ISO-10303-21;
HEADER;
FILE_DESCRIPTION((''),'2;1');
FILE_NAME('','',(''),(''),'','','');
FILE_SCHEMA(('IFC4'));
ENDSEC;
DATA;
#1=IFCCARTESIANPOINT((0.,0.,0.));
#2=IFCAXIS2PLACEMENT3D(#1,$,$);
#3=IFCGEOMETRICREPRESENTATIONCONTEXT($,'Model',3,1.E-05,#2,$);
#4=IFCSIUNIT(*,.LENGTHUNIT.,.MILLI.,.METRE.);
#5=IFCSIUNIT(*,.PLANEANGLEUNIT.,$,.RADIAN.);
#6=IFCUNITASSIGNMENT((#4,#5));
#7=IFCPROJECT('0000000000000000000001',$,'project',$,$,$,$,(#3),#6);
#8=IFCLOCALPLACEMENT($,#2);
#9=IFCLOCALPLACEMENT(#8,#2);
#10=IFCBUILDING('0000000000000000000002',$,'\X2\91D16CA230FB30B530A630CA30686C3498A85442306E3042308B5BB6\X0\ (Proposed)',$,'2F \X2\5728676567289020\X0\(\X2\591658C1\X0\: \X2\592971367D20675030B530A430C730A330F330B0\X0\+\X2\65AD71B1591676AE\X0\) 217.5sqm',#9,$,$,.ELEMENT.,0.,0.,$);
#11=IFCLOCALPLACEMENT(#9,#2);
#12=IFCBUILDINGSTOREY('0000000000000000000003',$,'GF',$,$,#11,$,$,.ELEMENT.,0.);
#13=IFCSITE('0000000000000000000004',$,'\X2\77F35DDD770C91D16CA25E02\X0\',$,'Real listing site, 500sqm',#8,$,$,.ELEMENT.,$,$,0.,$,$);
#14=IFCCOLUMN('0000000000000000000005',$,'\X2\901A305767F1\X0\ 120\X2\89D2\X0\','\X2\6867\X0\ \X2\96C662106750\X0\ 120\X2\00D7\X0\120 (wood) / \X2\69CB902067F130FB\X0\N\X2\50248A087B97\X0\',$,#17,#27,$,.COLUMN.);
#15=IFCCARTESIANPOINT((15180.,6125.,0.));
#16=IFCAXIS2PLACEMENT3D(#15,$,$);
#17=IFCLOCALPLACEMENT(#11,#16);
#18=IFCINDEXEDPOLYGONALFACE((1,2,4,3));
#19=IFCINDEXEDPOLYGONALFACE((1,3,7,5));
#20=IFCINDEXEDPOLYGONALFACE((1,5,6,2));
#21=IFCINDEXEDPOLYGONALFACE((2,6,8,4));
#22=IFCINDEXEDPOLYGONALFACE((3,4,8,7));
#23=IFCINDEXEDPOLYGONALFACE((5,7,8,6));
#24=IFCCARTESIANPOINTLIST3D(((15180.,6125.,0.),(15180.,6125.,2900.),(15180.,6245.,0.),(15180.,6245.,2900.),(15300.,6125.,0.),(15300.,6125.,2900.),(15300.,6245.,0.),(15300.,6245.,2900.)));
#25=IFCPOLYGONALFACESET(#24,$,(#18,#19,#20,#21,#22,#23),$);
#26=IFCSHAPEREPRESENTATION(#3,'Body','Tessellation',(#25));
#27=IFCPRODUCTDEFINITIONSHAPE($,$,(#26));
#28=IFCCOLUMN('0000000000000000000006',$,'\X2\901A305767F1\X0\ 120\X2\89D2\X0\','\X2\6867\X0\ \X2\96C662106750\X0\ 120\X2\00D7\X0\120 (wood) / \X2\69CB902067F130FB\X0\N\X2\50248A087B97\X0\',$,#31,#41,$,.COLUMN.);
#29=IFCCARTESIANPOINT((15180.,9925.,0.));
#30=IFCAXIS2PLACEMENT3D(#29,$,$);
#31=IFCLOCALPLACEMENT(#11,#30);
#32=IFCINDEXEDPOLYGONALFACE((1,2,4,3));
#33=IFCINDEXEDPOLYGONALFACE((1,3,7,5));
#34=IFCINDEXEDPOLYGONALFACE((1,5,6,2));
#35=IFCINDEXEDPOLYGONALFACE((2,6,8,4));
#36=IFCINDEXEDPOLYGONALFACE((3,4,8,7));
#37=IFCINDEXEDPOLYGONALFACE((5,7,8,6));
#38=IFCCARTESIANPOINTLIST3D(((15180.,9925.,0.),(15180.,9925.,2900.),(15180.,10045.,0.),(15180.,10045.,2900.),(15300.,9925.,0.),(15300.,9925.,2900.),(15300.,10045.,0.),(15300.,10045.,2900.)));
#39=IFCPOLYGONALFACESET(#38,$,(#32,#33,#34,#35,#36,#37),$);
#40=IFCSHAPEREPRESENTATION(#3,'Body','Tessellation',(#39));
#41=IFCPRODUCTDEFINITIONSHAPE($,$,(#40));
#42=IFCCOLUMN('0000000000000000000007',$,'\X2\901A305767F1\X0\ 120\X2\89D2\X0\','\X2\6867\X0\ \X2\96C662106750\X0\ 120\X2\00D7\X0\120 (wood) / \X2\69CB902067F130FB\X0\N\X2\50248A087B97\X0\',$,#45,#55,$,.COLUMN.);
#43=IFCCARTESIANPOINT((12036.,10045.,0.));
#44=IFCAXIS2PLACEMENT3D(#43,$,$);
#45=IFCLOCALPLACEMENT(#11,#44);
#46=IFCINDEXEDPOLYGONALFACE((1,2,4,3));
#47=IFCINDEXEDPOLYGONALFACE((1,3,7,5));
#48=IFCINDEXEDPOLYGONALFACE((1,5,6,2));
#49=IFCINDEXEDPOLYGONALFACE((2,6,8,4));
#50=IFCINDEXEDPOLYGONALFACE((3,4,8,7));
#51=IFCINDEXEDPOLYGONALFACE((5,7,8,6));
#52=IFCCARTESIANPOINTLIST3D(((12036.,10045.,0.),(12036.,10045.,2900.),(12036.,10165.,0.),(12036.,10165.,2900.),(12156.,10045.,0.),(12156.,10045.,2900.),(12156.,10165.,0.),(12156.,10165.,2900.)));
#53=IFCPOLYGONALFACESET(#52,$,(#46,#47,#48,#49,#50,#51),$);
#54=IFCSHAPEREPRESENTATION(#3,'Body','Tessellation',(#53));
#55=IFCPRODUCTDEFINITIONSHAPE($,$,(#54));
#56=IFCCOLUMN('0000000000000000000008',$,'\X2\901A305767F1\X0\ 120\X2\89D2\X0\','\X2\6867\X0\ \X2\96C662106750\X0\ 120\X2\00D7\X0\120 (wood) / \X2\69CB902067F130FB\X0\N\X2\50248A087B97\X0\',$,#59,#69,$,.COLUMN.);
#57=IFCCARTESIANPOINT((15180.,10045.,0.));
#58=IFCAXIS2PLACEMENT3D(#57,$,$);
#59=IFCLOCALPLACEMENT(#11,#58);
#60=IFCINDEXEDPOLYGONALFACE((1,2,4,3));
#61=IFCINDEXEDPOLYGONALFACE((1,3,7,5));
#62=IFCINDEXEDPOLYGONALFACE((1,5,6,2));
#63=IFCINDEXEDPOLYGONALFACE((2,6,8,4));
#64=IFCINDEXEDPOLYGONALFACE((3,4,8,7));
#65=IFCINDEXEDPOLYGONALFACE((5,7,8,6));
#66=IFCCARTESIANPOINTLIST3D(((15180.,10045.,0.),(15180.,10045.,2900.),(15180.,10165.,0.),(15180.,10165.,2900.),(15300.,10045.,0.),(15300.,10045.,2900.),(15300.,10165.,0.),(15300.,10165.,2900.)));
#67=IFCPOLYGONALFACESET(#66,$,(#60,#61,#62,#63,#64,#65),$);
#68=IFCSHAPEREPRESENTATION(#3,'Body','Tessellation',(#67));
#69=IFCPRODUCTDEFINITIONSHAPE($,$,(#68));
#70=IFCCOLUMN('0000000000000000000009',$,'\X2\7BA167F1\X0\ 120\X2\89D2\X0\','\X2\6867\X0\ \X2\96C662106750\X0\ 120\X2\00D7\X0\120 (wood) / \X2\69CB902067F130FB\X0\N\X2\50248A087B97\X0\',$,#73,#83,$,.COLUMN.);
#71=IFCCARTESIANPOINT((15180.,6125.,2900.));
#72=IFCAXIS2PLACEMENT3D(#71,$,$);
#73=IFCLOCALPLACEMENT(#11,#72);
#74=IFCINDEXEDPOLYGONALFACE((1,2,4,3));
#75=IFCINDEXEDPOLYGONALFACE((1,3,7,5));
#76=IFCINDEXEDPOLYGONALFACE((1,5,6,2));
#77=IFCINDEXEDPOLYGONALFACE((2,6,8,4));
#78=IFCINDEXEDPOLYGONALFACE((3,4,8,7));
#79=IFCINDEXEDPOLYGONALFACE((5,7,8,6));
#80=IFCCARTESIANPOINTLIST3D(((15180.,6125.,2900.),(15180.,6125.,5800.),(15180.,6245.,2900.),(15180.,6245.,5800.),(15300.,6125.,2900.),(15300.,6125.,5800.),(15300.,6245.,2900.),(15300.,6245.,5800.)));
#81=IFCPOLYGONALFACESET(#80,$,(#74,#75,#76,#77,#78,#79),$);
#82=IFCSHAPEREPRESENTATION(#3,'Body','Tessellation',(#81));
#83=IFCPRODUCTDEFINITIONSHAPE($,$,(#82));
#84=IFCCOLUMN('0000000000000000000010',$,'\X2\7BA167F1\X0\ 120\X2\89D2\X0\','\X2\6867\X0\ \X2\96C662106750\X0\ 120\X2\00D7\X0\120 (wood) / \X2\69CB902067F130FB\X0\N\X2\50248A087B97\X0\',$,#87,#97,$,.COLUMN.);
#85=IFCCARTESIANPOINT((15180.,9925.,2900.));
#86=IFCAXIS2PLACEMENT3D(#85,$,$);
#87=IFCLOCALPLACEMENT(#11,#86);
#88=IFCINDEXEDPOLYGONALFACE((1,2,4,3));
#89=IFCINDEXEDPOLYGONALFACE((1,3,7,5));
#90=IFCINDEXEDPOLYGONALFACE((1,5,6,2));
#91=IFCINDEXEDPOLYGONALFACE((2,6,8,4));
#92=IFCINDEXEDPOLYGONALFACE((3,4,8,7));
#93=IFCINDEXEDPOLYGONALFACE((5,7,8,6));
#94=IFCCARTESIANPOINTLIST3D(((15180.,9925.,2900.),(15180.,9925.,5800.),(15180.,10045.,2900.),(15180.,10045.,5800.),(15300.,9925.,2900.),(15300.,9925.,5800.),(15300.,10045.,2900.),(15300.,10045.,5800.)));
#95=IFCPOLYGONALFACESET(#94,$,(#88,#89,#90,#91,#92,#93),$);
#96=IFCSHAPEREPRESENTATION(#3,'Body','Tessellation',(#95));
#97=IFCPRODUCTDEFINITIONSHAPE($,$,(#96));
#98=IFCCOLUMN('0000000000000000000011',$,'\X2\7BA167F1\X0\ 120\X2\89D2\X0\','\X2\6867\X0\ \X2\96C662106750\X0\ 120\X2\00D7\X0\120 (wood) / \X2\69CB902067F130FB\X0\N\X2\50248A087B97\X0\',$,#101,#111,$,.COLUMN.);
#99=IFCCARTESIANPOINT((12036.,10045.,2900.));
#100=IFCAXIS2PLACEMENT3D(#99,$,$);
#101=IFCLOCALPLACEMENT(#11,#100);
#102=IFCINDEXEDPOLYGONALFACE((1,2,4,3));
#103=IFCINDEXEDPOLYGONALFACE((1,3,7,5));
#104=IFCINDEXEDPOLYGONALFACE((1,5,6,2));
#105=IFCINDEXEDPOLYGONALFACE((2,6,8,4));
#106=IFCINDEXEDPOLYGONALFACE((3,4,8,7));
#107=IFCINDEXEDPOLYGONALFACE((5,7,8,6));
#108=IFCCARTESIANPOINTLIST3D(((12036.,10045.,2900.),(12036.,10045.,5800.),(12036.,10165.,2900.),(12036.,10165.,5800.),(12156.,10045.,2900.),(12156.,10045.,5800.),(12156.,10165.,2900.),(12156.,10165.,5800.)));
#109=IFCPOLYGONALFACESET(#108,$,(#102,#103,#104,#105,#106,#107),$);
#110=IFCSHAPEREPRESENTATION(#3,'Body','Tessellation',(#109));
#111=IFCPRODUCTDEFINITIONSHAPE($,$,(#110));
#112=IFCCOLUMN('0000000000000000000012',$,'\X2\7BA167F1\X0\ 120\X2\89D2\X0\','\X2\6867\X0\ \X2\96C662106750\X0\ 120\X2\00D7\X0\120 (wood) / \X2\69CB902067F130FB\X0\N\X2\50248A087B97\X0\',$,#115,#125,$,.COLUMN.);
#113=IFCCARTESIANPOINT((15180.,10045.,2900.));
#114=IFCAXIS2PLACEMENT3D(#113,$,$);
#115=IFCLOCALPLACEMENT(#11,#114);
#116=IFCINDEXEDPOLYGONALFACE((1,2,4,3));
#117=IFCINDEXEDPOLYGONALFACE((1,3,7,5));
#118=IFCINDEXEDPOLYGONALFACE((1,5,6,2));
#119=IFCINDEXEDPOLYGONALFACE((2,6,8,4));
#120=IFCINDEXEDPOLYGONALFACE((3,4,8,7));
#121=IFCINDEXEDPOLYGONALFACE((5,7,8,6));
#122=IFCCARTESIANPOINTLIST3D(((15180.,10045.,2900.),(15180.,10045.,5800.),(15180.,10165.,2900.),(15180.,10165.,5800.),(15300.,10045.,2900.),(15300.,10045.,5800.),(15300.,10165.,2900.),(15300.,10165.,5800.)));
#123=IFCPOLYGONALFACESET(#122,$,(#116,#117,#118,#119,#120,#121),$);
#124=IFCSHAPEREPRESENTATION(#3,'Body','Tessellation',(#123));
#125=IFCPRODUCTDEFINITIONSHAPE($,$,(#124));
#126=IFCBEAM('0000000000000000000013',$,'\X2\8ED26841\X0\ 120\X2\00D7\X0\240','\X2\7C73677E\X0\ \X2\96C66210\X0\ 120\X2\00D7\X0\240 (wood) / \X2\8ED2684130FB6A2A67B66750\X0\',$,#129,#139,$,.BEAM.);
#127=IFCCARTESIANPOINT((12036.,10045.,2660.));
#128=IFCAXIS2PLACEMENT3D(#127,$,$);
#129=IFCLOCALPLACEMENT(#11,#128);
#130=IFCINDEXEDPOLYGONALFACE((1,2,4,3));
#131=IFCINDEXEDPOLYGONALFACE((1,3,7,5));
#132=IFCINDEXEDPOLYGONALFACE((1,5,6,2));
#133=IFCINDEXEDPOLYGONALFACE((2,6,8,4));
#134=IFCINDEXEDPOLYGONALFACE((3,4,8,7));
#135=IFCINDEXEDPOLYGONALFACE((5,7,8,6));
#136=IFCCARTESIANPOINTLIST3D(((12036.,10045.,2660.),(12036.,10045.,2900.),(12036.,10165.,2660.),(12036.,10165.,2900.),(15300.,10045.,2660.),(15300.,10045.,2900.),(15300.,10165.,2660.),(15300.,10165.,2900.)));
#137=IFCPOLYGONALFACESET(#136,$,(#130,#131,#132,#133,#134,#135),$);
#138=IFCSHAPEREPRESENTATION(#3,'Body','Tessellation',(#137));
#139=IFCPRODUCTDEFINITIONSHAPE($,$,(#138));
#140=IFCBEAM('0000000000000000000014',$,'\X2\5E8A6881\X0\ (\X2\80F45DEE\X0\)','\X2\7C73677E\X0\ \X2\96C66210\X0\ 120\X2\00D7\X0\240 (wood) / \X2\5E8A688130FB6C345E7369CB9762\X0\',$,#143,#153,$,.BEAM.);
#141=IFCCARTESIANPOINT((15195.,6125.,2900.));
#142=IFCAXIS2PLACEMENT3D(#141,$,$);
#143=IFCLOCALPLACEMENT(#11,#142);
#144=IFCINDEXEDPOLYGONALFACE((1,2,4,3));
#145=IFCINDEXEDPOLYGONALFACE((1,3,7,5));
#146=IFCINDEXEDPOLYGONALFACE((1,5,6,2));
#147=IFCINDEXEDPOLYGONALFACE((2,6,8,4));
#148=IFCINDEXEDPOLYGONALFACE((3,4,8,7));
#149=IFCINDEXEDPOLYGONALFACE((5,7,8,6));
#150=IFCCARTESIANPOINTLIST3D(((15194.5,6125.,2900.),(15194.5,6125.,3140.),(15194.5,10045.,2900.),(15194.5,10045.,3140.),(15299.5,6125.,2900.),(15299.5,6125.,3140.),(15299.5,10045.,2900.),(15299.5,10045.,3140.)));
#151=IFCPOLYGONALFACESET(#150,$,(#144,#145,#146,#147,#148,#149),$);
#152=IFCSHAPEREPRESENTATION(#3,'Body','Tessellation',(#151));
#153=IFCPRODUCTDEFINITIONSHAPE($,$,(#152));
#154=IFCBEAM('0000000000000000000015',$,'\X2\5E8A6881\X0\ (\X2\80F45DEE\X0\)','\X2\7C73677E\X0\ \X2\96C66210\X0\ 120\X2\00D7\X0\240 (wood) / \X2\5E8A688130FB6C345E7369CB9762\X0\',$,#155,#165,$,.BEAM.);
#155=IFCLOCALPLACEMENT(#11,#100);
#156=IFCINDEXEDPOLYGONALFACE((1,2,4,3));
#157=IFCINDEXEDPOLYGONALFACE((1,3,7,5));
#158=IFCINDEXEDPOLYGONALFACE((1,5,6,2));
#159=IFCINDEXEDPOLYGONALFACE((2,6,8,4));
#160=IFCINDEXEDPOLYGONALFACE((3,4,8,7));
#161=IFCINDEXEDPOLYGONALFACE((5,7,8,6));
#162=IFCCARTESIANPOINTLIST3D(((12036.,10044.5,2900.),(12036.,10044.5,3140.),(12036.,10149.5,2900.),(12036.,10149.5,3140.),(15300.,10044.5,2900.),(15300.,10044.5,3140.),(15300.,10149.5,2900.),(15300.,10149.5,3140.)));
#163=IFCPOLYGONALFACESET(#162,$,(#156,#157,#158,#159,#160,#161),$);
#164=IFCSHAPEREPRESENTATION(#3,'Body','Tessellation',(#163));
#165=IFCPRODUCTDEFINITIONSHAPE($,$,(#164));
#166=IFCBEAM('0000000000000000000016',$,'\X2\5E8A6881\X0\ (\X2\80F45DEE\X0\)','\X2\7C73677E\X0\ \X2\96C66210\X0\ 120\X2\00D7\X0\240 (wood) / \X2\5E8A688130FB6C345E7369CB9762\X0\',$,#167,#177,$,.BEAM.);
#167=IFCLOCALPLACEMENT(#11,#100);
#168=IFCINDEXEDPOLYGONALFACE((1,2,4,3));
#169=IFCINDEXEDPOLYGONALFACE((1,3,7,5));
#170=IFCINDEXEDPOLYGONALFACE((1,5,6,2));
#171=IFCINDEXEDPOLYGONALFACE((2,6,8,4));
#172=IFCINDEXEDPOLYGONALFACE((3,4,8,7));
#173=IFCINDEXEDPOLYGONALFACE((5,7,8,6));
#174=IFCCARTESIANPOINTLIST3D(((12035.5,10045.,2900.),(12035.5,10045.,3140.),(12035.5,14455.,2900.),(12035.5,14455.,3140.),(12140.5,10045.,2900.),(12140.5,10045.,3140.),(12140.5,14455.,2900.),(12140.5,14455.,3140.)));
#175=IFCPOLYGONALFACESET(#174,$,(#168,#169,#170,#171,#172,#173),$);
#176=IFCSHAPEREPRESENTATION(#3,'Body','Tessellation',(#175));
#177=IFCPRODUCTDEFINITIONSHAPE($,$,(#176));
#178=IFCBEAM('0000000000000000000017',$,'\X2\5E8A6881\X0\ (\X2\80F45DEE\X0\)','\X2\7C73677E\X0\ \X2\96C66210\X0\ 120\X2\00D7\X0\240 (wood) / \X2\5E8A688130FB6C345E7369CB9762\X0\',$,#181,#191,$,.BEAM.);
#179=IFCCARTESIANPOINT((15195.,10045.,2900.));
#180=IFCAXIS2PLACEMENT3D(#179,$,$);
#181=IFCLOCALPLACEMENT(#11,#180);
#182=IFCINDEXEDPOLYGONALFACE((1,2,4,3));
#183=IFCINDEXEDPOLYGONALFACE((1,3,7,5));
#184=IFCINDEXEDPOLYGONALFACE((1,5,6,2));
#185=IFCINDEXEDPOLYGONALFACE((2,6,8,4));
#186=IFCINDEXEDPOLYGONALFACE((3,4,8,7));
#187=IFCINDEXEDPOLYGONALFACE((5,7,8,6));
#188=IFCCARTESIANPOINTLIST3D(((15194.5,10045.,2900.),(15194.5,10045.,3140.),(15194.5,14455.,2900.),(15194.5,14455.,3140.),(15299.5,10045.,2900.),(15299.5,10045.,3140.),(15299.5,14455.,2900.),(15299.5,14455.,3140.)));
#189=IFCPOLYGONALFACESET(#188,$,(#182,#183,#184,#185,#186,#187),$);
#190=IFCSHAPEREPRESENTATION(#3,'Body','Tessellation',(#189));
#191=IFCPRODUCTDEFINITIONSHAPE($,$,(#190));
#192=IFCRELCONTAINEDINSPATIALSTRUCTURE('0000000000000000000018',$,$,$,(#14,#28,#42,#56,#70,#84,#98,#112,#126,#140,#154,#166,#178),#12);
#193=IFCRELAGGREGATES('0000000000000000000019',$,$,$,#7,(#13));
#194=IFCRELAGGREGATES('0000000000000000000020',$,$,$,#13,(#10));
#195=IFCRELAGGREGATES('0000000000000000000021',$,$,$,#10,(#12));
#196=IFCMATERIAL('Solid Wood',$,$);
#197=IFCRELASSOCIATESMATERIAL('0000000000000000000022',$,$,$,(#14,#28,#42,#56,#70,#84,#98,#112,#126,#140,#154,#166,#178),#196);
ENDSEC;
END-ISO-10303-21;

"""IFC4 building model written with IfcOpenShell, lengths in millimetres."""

from ifc_helpers import new_model, si_unit, frame, frame_2d, origin, place, context, project, spatial, rectangle, extrude, material, element, save


model = new_model("IFC4")

# Units and contexts
model_context = context("Model", 3, precision=1e-05, world=origin())
ifc_project = project(units=[si_unit("LENGTHUNIT", "METRE", prefix="MILLI"), si_unit("PLANEANGLEUNIT", "RADIAN")], contexts=[model_context])

# Site, building, storey
site_placement = place(None, origin())
site = spatial("IfcSite", under=ifc_project, at=site_placement, Name="石川県金沢市", ObjectType="Real listing site, 500sqm", CompositionType="ELEMENT", RefElevation=0.0)
building_placement = place(site_placement, origin())
building = spatial("IfcBuilding", under=site, at=building_placement, Name="金沢・サウナと水風呂のある家 (Proposed)", ObjectType="2F 在来木造(外壁: 天然素材サイディング+断熱外皮) 217.5sqm", CompositionType="ELEMENT", ElevationOfRefHeight=0.0, ElevationOfTerrain=0.0)
storey_placement = place(building_placement, origin())
storey = spatial("IfcBuildingStorey", under=building, at=storey_placement, Name="GF", CompositionType="ELEMENT", Elevation=0.0)

# Columns
ifc_material_1 = material(Name="Solid Wood")
column_1_placement = place(storey_placement, frame((15180.0, 6125.0, 0.0)))
element("IfcColumn", 1, at=column_1_placement, inside=storey, material=ifc_material_1, Name="通し柱 120角", Description="桧 集成材 120×120 (wood) / 構造柱・N値計算", PredefinedType="COLUMN", context=model_context, shape_type="SweptSolid", body=[
    extrude(rectangle(XDim=120.0, YDim=120.0, at=frame_2d((60.0, 60.0))), frame((15180.0, 6125.0, 0.0)), (0.0, 0.0, 1.0), 2900.0),
])
column_2_placement = place(storey_placement, frame((15180.0, 9925.0, 0.0)))
element("IfcColumn", 2, at=column_2_placement, inside=storey, material=ifc_material_1, Name="通し柱 120角", Description="桧 集成材 120×120 (wood) / 構造柱・N値計算", PredefinedType="COLUMN", context=model_context, shape_type="SweptSolid", body=[
    extrude(rectangle(XDim=120.0, YDim=120.0, at=frame_2d((60.0, 60.0))), frame((15180.0, 9925.0, 0.0)), (0.0, 0.0, 1.0), 2900.0),
])
column_3_placement = place(storey_placement, frame((12036.0, 10045.0, 0.0)))
element("IfcColumn", 3, at=column_3_placement, inside=storey, material=ifc_material_1, Name="通し柱 120角", Description="桧 集成材 120×120 (wood) / 構造柱・N値計算", PredefinedType="COLUMN", context=model_context, shape_type="SweptSolid", body=[
    extrude(rectangle(XDim=120.0, YDim=120.0, at=frame_2d((60.0, 60.0))), frame((12036.0, 10045.0, 0.0)), (0.0, 0.0, 1.0), 2900.0),
])
column_4_placement = place(storey_placement, frame((15180.0, 10045.0, 0.0)))
element("IfcColumn", 4, at=column_4_placement, inside=storey, material=ifc_material_1, Name="通し柱 120角", Description="桧 集成材 120×120 (wood) / 構造柱・N値計算", PredefinedType="COLUMN", context=model_context, shape_type="SweptSolid", body=[
    extrude(rectangle(XDim=120.0, YDim=120.0, at=frame_2d((60.0, 60.0))), frame((15180.0, 10045.0, 0.0)), (0.0, 0.0, 1.0), 2900.0),
])
column_5_placement = place(storey_placement, frame((15180.0, 6125.0, 2900.0)))
element("IfcColumn", 5, at=column_5_placement, inside=storey, material=ifc_material_1, Name="管柱 120角", Description="桧 集成材 120×120 (wood) / 構造柱・N値計算", PredefinedType="COLUMN", context=model_context, shape_type="SweptSolid", body=[
    extrude(rectangle(XDim=120.0, YDim=120.0, at=frame_2d((60.0, 60.0))), frame((15180.0, 6125.0, 2900.0)), (0.0, 0.0, 1.0), 2900.0),
])
column_6_placement = place(storey_placement, frame((15180.0, 9925.0, 2900.0)))
element("IfcColumn", 6, at=column_6_placement, inside=storey, material=ifc_material_1, Name="管柱 120角", Description="桧 集成材 120×120 (wood) / 構造柱・N値計算", PredefinedType="COLUMN", context=model_context, shape_type="SweptSolid", body=[
    extrude(rectangle(XDim=120.0, YDim=120.0, at=frame_2d((60.0, 60.0))), frame((15180.0, 9925.0, 2900.0)), (0.0, 0.0, 1.0), 2900.0),
])
column_7_placement = place(storey_placement, frame((12036.0, 10045.0, 2900.0)))
element("IfcColumn", 7, at=column_7_placement, inside=storey, material=ifc_material_1, Name="管柱 120角", Description="桧 集成材 120×120 (wood) / 構造柱・N値計算", PredefinedType="COLUMN", context=model_context, shape_type="SweptSolid", body=[
    extrude(rectangle(XDim=120.0, YDim=120.0, at=frame_2d((60.0, 60.0))), frame((12036.0, 10045.0, 2900.0)), (0.0, 0.0, 1.0), 2900.0),
])
column_8_placement = place(storey_placement, frame((15180.0, 10045.0, 2900.0)))
element("IfcColumn", 8, at=column_8_placement, inside=storey, material=ifc_material_1, Name="管柱 120角", Description="桧 集成材 120×120 (wood) / 構造柱・N値計算", PredefinedType="COLUMN", context=model_context, shape_type="SweptSolid", body=[
    extrude(rectangle(XDim=120.0, YDim=120.0, at=frame_2d((60.0, 60.0))), frame((15180.0, 10045.0, 2900.0)), (0.0, 0.0, 1.0), 2900.0),
])

# Beams
beam_1_placement = place(storey_placement, frame((12036.0, 10045.0, 2660.0)))
element("IfcBeam", 9, at=beam_1_placement, inside=storey, material=ifc_material_1, Name="軒桁 120×240", Description="米松 集成 120×240 (wood) / 軒桁・横架材", PredefinedType="BEAM", context=model_context, shape_type="SweptSolid", body=[
    extrude(rectangle(XDim=3264.0, YDim=120.0, at=frame_2d((1632.0, 60.0))), frame((12036.0, 10045.0, 2660.0)), (0.0, 0.0, 1.0), 240.0),
])
beam_2_placement = place(storey_placement, frame((15195.0, 6125.0, 2900.0)))
element("IfcBeam", 10, at=beam_2_placement, inside=storey, material=ifc_material_1, Name="床梁 (胴差)", Description="米松 集成 120×240 (wood) / 床梁・水平構面", PredefinedType="BEAM", context=model_context, shape_type="SweptSolid", body=[
    extrude(rectangle(XDim=105.0, YDim=3920.0, at=frame_2d((52.0, 1960.0))), frame((15195.0, 6125.0, 2900.0)), (0.0, 0.0, 1.0), 240.0),
])
beam_3_placement = place(storey_placement, frame((12036.0, 10045.0, 2900.0)))
element("IfcBeam", 11, at=beam_3_placement, inside=storey, material=ifc_material_1, Name="床梁 (胴差)", Description="米松 集成 120×240 (wood) / 床梁・水平構面", PredefinedType="BEAM", context=model_context, shape_type="SweptSolid", body=[
    extrude(rectangle(XDim=3264.0, YDim=105.0, at=frame_2d((1632.0, 52.0))), frame((12036.0, 10045.0, 2900.0)), (0.0, 0.0, 1.0), 240.0),
])
beam_4_placement = place(storey_placement, frame((12036.0, 10045.0, 2900.0)))
element("IfcBeam", 12, at=beam_4_placement, inside=storey, material=ifc_material_1, Name="床梁 (胴差)", Description="米松 集成 120×240 (wood) / 床梁・水平構面", PredefinedType="BEAM", context=model_context, shape_type="SweptSolid", body=[
    extrude(rectangle(XDim=105.0, YDim=4410.0, at=frame_2d((52.0, 2205.0))), frame((12036.0, 10045.0, 2900.0)), (0.0, 0.0, 1.0), 240.0),
])
beam_5_placement = place(storey_placement, frame((15195.0, 10045.0, 2900.0)))
element("IfcBeam", 13, at=beam_5_placement, inside=storey, material=ifc_material_1, Name="床梁 (胴差)", Description="米松 集成 120×240 (wood) / 床梁・水平構面", PredefinedType="BEAM", context=model_context, shape_type="SweptSolid", body=[
    extrude(rectangle(XDim=105.0, YDim=4410.0, at=frame_2d((52.0, 2205.0))), frame((15195.0, 10045.0, 2900.0)), (0.0, 0.0, 1.0), 240.0),
])

save(model, "model.ifc")
